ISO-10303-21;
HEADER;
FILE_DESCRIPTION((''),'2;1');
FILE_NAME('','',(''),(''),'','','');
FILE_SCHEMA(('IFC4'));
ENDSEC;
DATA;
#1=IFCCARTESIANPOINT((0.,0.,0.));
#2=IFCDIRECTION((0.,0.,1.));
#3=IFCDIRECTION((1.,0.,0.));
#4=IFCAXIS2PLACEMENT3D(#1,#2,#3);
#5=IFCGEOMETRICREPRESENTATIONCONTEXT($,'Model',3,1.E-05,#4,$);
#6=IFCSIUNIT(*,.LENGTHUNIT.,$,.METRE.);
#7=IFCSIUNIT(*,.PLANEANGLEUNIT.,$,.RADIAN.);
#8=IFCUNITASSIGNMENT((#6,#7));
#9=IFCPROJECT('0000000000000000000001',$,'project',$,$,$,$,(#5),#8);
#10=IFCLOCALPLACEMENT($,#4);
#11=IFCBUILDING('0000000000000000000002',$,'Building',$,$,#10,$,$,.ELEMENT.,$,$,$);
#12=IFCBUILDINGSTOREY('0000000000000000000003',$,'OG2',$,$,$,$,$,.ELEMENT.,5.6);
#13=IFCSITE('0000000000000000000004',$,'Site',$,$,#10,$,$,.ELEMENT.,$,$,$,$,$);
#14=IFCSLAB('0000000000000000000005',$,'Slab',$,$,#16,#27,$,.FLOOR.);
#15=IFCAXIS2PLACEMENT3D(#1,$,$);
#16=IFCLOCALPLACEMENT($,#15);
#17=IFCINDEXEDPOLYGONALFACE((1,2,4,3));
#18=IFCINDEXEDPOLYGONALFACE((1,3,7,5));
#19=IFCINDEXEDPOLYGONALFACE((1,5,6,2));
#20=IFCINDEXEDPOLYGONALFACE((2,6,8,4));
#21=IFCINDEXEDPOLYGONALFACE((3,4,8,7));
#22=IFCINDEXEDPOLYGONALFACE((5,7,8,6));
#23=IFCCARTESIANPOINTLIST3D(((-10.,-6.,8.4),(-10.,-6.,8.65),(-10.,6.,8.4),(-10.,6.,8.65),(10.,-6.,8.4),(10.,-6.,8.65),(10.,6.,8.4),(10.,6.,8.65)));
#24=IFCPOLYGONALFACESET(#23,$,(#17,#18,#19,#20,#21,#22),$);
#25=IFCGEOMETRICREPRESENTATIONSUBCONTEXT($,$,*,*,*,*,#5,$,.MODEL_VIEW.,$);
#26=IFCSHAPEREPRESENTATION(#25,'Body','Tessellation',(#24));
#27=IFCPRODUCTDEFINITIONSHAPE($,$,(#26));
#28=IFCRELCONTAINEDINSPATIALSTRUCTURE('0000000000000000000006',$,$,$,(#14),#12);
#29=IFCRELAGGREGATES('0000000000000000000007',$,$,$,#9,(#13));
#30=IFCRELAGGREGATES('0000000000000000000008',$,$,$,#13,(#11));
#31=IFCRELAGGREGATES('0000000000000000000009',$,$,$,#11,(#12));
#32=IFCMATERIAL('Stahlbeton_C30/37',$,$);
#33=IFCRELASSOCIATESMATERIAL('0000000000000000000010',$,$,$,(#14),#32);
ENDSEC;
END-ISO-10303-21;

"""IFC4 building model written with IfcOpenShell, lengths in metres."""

from ifc_helpers import new_model, si_unit, frame, frame_2d, origin, origin_with_axes, place, context, subcontext, project, spatial, rectangle, extrude, material, element, save


model = new_model("IFC4")

# Units and contexts
model_context = context("Model", 3, precision=1e-05, world=origin_with_axes())
sub_context = subcontext(model_context, None, None, "MODEL_VIEW")
ifc_project = project(units=[si_unit("LENGTHUNIT", "METRE"), si_unit("PLANEANGLEUNIT", "RADIAN")], contexts=[model_context])

# Site, building, storey
placement_1 = place(None, origin_with_axes())
site = spatial("IfcSite", under=ifc_project, at=placement_1, Name="Site", CompositionType="ELEMENT")
building = spatial("IfcBuilding", under=site, at=placement_1, Name="Building", CompositionType="ELEMENT")
storey = spatial("IfcBuildingStorey", under=building, Name="OG2", CompositionType="ELEMENT", Elevation=5.6)

# Slab
ifc_material = material(Name="Stahlbeton_C30/37")
placement_2 = place(None, origin_with_axes())
placement_3 = place(placement_2, frame((0.0, 0.0, 5.6)))
slab_placement = place(placement_3, frame((-10.0, -6.0, 2.8)))
element("IfcSlab", 1, at=slab_placement, inside=storey, material=ifc_material, Name="Slab", PredefinedType="FLOOR", context=sub_context, shape_type="SweptSolid", body=[
    extrude(rectangle(XDim=20.0, YDim=12.0, at=frame_2d((10.0, 6.0))), origin(), (0.0, 0.0, 1.0), 0.25),
])

save(model, "model.ifc")
